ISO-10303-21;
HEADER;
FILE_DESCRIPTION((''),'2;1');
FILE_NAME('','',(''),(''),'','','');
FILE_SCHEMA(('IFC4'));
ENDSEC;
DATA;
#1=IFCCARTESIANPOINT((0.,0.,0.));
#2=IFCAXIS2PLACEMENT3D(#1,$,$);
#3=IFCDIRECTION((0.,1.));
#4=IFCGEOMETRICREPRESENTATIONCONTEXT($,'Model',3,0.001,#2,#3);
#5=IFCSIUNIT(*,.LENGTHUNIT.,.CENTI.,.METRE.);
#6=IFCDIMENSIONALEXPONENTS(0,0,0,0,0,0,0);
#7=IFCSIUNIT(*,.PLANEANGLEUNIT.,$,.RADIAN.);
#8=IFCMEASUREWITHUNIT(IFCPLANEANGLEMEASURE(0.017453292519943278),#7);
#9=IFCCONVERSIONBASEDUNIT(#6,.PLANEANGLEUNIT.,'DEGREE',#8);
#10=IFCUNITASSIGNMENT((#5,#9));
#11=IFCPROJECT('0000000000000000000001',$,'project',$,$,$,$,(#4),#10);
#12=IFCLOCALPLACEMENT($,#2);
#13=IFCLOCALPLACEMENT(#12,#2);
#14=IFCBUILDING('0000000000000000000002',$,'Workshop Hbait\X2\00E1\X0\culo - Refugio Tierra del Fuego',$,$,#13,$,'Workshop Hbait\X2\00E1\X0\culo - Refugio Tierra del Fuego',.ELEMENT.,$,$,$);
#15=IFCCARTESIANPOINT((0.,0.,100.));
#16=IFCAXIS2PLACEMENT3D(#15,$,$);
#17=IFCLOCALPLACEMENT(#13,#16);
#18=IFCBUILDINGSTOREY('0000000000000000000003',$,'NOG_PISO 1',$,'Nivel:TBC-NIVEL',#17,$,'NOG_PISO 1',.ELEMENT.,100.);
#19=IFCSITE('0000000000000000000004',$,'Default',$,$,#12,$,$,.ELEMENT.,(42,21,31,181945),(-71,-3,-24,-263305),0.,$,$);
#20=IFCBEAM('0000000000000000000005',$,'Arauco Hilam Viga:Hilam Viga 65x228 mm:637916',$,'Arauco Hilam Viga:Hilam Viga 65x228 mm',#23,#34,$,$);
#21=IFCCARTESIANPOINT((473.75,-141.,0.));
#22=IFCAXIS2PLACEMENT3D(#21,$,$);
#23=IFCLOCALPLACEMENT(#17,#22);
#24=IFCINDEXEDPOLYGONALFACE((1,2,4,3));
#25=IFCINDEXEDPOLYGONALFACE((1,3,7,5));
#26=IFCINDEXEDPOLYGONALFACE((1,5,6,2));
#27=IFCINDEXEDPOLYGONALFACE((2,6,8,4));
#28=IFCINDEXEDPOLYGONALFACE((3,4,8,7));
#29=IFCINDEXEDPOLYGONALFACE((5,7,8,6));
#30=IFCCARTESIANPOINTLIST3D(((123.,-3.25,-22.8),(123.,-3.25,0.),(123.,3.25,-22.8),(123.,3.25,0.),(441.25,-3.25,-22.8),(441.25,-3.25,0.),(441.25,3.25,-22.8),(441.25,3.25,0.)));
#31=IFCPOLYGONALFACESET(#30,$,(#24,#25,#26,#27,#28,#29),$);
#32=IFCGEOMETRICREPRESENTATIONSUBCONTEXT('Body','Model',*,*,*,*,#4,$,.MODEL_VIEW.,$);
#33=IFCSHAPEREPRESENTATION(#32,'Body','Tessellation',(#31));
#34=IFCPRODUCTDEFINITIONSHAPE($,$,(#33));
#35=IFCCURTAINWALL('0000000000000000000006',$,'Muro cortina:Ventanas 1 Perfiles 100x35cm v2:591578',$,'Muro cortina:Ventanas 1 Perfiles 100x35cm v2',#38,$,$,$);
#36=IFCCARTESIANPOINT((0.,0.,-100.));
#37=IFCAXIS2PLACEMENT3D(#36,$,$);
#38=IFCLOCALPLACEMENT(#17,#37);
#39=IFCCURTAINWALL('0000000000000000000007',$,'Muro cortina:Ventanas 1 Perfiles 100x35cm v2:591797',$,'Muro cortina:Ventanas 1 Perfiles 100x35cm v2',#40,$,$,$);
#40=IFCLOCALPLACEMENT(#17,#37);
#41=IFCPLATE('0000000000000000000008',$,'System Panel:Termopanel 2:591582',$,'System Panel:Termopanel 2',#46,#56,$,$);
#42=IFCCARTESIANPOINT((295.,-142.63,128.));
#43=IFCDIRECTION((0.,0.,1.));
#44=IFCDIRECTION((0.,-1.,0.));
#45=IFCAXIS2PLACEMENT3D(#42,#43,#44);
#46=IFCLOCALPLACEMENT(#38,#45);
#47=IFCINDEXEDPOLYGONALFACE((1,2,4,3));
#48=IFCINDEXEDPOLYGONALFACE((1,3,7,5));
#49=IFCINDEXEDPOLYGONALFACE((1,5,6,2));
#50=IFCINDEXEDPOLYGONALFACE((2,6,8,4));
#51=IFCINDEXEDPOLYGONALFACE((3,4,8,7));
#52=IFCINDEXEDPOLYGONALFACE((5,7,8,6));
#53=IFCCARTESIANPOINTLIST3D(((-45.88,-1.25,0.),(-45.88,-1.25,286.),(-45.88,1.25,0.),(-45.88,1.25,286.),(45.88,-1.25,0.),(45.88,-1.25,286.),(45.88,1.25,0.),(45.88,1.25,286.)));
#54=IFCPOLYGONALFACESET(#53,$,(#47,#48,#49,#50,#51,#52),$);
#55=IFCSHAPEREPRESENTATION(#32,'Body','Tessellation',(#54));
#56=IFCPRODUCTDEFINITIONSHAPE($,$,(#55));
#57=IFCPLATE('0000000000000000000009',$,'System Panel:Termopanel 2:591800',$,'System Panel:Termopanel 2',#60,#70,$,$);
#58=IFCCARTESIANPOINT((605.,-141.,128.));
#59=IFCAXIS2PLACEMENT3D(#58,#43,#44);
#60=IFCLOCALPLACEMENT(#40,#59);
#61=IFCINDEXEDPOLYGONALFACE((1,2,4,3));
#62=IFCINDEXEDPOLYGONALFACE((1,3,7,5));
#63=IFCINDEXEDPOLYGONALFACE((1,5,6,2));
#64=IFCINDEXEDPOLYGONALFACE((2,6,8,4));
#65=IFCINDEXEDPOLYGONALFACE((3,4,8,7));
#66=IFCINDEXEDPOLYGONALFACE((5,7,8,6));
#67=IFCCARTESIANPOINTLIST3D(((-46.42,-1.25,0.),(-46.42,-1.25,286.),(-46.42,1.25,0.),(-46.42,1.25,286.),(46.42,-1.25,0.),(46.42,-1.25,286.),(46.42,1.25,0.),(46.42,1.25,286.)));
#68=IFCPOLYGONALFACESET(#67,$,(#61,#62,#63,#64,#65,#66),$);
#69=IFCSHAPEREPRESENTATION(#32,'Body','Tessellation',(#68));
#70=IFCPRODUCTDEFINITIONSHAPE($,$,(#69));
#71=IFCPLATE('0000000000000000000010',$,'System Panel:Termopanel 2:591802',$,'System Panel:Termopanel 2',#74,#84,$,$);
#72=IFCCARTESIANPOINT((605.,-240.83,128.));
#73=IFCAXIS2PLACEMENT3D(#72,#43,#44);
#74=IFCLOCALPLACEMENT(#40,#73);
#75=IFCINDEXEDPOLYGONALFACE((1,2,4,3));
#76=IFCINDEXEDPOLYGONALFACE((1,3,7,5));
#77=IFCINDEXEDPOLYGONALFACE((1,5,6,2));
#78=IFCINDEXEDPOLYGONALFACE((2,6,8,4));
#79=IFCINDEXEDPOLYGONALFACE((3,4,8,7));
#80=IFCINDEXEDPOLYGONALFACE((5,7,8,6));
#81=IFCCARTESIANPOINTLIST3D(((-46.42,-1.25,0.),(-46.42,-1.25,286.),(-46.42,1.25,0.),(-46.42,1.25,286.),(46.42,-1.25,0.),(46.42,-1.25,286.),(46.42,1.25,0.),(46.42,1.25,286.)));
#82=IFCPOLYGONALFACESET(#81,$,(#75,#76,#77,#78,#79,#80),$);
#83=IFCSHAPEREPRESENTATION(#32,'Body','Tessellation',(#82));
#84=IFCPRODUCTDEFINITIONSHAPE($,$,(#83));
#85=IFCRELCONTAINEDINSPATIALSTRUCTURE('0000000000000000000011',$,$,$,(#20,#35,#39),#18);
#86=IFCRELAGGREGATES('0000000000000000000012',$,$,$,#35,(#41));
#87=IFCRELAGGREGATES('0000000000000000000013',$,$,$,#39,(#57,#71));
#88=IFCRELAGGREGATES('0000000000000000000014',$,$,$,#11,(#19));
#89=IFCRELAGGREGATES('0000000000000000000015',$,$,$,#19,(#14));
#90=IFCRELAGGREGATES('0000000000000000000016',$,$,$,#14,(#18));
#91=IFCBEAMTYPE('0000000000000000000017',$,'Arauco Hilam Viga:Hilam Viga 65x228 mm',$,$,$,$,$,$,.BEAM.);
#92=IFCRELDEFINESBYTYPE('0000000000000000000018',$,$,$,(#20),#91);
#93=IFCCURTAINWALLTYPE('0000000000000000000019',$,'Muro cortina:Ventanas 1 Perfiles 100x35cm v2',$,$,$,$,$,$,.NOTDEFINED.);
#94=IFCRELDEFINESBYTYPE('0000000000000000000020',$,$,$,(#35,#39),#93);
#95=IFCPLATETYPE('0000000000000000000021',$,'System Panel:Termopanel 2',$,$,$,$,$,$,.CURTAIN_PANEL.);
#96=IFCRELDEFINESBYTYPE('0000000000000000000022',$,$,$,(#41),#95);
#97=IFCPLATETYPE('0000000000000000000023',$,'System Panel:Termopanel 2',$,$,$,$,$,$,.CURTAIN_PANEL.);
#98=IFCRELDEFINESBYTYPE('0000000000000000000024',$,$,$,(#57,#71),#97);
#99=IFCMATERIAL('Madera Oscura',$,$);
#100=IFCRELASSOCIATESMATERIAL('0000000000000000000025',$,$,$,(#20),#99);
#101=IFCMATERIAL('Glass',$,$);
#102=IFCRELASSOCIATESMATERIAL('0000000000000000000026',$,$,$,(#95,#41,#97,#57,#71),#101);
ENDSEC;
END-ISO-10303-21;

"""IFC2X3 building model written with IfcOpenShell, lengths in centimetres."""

from ifc_helpers import new_model, entity, si_unit, converted_unit, direction, frame, frame_2d, origin, origin_2d_with_axis, place, context, subcontext, project, spatial, rectangle, extrude, source, transform, mapped, material, type_object, type_shapes, element, aggregate, save


model = new_model("IFC2X3")

# Units and contexts
model_context = context("Model", 3, precision=0.001, world=origin(), true_north=direction((0.0, 1.0)))
body_context = subcontext(model_context, "Body", "Model", "MODEL_VIEW")
ifc_project = project(units=[si_unit("LENGTHUNIT", "METRE", prefix="CENTI"), converted_unit("PLANEANGLEUNIT", "DEGREE", entity("IfcPlaneAngleMeasure", 0.017453292519943278), si_unit("PLANEANGLEUNIT", "RADIAN"), dimensions=[0, 0, 0, 0, 0, 0, 0])], contexts=[model_context])

# Site, building, storey
site_placement = place(None, origin())
site = spatial("IfcSite", under=ifc_project, at=site_placement, Name="Default", CompositionType="ELEMENT", RefLatitude=(42, 21, 31, 181945), RefLongitude=(-71, -3, -24, -263305), RefElevation=0.0)
building_placement = place(site_placement, origin())
building = spatial("IfcBuilding", under=site, at=building_placement, Name="Workshop Hbaitáculo - Refugio Tierra del Fuego", LongName="Workshop Hbaitáculo - Refugio Tierra del Fuego", CompositionType="ELEMENT")
storey_placement = place(building_placement, frame((0.0, 0.0, 100.0)))
storey = spatial("IfcBuildingStorey", under=building, at=storey_placement, Name="NOG_PISO 1", ObjectType="Nivel:TBC-NIVEL", LongName="NOG_PISO 1", CompositionType="ELEMENT", Elevation=100.0)

# Beam
ifc_material_1 = material(Name="Madera Oscura")
beam_type = type_object("IfcBeamType", Name="Arauco Hilam Viga:Hilam Viga 65x228 mm", PredefinedType="BEAM")
beam_1_placement = place(storey_placement, frame((473.75, -141.0, 0.0)))
element("IfcBeam", 1, at=beam_1_placement, inside=storey, type_object=beam_type, material=ifc_material_1, Name="Arauco Hilam Viga:Hilam Viga 65x228 mm:637916", ObjectType="Arauco Hilam Viga:Hilam Viga 65x228 mm", context=body_context, shape_type="SweptSolid", body=[
    extrude(rectangle(XDim=22.8, YDim=6.5, at=origin_2d_with_axis()), frame((123.0, 0.0, -11.4), z_axis=(1.0, 0.0, 0.0), x_axis=(0.0, 0.0, -1.0)), (0.0, 0.0, 1.0), 318.25),
])

# Curtain walls
curtain_wall_type = type_object("IfcCurtainWallType", Name="Muro cortina:Ventanas 1 Perfiles 100x35cm v2", PredefinedType="NOTDEFINED")
curtain_wall_1_placement = place(storey_placement, frame((0.0, 0.0, -100.0)))
curtain_wall_1 = element("IfcCurtainWall", 2, at=curtain_wall_1_placement, inside=storey, type_object=curtain_wall_type, Name="Muro cortina:Ventanas 1 Perfiles 100x35cm v2:591578", ObjectType="Muro cortina:Ventanas 1 Perfiles 100x35cm v2")
curtain_wall_2_placement = place(storey_placement, frame((0.0, 0.0, -100.0)))
curtain_wall_2 = element("IfcCurtainWall", 3, at=curtain_wall_2_placement, inside=storey, type_object=curtain_wall_type, Name="Muro cortina:Ventanas 1 Perfiles 100x35cm v2:591797", ObjectType="Muro cortina:Ventanas 1 Perfiles 100x35cm v2")

# Plates
ifc_material_2 = material(Name="Glass")
plate_type_1 = type_object("IfcPlateType", Name="System Panel:Termopanel 2", PredefinedType="CURTAIN_PANEL", material=ifc_material_2)
shared_shape_1 = source(origin(), body_context, "Body", "SweptSolid", [
    extrude(rectangle(XDim=2.5, YDim=91.75, at=frame_2d((0.0, 0.0), x_axis=(1.0, 0.0))), frame((0.0, 0.0, 0.0), z_axis=(0.0, 0.0, 1.0), x_axis=(0.0, 1.0, 0.0)), (0.0, 0.0, 1.0), 286.0),
])
type_shapes(plate_type_1, [shared_shape_1])
plate_1_placement = place(curtain_wall_1_placement, frame((295.0, -142.63, 128.0), z_axis=(0.0, 0.0, 1.0), x_axis=(0.0, -1.0, 0.0)))
plate_1 = element("IfcPlate", 4, at=plate_1_placement, type_object=plate_type_1, material=ifc_material_2, Name="System Panel:Termopanel 2:591582", ObjectType="System Panel:Termopanel 2", context=body_context, shape_type="MappedRepresentation", body=[
    mapped(shared_shape_1, transform((0.0, 0.0, 0.0), scale=1.0)),
])
aggregate(curtain_wall_1, [plate_1])
plate_type_2 = type_object("IfcPlateType", Name="System Panel:Termopanel 2", PredefinedType="CURTAIN_PANEL", material=ifc_material_2)
shared_shape_2 = source(origin(), body_context, "Body", "SweptSolid", [
    extrude(rectangle(XDim=2.5, YDim=92.83, at=origin_2d_with_axis()), frame((0.0, 0.0, 0.0), z_axis=(0.0, 0.0, 1.0), x_axis=(0.0, 1.0, 0.0)), (0.0, 0.0, 1.0), 286.0),
])
type_shapes(plate_type_2, [shared_shape_2])
plate_2_placement = place(curtain_wall_2_placement, frame((605.0, -141.0, 128.0), z_axis=(0.0, 0.0, 1.0), x_axis=(0.0, -1.0, 0.0)))
plate_2 = element("IfcPlate", 5, at=plate_2_placement, type_object=plate_type_2, material=ifc_material_2, Name="System Panel:Termopanel 2:591800", ObjectType="System Panel:Termopanel 2", context=body_context, shape_type="MappedRepresentation", body=[
    mapped(shared_shape_2, transform((0.0, 0.0, 0.0), scale=1.0)),
])
plate_3_placement = place(curtain_wall_2_placement, frame((605.0, -240.83, 128.0), z_axis=(0.0, 0.0, 1.0), x_axis=(0.0, -1.0, 0.0)))
plate_3 = element("IfcPlate", 6, at=plate_3_placement, type_object=plate_type_2, material=ifc_material_2, Name="System Panel:Termopanel 2:591802", ObjectType="System Panel:Termopanel 2", context=body_context, shape_type="MappedRepresentation", body=[
    mapped(shared_shape_2, transform((0.0, 0.0, 0.0), scale=1.0)),
])
aggregate(curtain_wall_2, [plate_2, plate_3])

save(model, "model.ifc")
